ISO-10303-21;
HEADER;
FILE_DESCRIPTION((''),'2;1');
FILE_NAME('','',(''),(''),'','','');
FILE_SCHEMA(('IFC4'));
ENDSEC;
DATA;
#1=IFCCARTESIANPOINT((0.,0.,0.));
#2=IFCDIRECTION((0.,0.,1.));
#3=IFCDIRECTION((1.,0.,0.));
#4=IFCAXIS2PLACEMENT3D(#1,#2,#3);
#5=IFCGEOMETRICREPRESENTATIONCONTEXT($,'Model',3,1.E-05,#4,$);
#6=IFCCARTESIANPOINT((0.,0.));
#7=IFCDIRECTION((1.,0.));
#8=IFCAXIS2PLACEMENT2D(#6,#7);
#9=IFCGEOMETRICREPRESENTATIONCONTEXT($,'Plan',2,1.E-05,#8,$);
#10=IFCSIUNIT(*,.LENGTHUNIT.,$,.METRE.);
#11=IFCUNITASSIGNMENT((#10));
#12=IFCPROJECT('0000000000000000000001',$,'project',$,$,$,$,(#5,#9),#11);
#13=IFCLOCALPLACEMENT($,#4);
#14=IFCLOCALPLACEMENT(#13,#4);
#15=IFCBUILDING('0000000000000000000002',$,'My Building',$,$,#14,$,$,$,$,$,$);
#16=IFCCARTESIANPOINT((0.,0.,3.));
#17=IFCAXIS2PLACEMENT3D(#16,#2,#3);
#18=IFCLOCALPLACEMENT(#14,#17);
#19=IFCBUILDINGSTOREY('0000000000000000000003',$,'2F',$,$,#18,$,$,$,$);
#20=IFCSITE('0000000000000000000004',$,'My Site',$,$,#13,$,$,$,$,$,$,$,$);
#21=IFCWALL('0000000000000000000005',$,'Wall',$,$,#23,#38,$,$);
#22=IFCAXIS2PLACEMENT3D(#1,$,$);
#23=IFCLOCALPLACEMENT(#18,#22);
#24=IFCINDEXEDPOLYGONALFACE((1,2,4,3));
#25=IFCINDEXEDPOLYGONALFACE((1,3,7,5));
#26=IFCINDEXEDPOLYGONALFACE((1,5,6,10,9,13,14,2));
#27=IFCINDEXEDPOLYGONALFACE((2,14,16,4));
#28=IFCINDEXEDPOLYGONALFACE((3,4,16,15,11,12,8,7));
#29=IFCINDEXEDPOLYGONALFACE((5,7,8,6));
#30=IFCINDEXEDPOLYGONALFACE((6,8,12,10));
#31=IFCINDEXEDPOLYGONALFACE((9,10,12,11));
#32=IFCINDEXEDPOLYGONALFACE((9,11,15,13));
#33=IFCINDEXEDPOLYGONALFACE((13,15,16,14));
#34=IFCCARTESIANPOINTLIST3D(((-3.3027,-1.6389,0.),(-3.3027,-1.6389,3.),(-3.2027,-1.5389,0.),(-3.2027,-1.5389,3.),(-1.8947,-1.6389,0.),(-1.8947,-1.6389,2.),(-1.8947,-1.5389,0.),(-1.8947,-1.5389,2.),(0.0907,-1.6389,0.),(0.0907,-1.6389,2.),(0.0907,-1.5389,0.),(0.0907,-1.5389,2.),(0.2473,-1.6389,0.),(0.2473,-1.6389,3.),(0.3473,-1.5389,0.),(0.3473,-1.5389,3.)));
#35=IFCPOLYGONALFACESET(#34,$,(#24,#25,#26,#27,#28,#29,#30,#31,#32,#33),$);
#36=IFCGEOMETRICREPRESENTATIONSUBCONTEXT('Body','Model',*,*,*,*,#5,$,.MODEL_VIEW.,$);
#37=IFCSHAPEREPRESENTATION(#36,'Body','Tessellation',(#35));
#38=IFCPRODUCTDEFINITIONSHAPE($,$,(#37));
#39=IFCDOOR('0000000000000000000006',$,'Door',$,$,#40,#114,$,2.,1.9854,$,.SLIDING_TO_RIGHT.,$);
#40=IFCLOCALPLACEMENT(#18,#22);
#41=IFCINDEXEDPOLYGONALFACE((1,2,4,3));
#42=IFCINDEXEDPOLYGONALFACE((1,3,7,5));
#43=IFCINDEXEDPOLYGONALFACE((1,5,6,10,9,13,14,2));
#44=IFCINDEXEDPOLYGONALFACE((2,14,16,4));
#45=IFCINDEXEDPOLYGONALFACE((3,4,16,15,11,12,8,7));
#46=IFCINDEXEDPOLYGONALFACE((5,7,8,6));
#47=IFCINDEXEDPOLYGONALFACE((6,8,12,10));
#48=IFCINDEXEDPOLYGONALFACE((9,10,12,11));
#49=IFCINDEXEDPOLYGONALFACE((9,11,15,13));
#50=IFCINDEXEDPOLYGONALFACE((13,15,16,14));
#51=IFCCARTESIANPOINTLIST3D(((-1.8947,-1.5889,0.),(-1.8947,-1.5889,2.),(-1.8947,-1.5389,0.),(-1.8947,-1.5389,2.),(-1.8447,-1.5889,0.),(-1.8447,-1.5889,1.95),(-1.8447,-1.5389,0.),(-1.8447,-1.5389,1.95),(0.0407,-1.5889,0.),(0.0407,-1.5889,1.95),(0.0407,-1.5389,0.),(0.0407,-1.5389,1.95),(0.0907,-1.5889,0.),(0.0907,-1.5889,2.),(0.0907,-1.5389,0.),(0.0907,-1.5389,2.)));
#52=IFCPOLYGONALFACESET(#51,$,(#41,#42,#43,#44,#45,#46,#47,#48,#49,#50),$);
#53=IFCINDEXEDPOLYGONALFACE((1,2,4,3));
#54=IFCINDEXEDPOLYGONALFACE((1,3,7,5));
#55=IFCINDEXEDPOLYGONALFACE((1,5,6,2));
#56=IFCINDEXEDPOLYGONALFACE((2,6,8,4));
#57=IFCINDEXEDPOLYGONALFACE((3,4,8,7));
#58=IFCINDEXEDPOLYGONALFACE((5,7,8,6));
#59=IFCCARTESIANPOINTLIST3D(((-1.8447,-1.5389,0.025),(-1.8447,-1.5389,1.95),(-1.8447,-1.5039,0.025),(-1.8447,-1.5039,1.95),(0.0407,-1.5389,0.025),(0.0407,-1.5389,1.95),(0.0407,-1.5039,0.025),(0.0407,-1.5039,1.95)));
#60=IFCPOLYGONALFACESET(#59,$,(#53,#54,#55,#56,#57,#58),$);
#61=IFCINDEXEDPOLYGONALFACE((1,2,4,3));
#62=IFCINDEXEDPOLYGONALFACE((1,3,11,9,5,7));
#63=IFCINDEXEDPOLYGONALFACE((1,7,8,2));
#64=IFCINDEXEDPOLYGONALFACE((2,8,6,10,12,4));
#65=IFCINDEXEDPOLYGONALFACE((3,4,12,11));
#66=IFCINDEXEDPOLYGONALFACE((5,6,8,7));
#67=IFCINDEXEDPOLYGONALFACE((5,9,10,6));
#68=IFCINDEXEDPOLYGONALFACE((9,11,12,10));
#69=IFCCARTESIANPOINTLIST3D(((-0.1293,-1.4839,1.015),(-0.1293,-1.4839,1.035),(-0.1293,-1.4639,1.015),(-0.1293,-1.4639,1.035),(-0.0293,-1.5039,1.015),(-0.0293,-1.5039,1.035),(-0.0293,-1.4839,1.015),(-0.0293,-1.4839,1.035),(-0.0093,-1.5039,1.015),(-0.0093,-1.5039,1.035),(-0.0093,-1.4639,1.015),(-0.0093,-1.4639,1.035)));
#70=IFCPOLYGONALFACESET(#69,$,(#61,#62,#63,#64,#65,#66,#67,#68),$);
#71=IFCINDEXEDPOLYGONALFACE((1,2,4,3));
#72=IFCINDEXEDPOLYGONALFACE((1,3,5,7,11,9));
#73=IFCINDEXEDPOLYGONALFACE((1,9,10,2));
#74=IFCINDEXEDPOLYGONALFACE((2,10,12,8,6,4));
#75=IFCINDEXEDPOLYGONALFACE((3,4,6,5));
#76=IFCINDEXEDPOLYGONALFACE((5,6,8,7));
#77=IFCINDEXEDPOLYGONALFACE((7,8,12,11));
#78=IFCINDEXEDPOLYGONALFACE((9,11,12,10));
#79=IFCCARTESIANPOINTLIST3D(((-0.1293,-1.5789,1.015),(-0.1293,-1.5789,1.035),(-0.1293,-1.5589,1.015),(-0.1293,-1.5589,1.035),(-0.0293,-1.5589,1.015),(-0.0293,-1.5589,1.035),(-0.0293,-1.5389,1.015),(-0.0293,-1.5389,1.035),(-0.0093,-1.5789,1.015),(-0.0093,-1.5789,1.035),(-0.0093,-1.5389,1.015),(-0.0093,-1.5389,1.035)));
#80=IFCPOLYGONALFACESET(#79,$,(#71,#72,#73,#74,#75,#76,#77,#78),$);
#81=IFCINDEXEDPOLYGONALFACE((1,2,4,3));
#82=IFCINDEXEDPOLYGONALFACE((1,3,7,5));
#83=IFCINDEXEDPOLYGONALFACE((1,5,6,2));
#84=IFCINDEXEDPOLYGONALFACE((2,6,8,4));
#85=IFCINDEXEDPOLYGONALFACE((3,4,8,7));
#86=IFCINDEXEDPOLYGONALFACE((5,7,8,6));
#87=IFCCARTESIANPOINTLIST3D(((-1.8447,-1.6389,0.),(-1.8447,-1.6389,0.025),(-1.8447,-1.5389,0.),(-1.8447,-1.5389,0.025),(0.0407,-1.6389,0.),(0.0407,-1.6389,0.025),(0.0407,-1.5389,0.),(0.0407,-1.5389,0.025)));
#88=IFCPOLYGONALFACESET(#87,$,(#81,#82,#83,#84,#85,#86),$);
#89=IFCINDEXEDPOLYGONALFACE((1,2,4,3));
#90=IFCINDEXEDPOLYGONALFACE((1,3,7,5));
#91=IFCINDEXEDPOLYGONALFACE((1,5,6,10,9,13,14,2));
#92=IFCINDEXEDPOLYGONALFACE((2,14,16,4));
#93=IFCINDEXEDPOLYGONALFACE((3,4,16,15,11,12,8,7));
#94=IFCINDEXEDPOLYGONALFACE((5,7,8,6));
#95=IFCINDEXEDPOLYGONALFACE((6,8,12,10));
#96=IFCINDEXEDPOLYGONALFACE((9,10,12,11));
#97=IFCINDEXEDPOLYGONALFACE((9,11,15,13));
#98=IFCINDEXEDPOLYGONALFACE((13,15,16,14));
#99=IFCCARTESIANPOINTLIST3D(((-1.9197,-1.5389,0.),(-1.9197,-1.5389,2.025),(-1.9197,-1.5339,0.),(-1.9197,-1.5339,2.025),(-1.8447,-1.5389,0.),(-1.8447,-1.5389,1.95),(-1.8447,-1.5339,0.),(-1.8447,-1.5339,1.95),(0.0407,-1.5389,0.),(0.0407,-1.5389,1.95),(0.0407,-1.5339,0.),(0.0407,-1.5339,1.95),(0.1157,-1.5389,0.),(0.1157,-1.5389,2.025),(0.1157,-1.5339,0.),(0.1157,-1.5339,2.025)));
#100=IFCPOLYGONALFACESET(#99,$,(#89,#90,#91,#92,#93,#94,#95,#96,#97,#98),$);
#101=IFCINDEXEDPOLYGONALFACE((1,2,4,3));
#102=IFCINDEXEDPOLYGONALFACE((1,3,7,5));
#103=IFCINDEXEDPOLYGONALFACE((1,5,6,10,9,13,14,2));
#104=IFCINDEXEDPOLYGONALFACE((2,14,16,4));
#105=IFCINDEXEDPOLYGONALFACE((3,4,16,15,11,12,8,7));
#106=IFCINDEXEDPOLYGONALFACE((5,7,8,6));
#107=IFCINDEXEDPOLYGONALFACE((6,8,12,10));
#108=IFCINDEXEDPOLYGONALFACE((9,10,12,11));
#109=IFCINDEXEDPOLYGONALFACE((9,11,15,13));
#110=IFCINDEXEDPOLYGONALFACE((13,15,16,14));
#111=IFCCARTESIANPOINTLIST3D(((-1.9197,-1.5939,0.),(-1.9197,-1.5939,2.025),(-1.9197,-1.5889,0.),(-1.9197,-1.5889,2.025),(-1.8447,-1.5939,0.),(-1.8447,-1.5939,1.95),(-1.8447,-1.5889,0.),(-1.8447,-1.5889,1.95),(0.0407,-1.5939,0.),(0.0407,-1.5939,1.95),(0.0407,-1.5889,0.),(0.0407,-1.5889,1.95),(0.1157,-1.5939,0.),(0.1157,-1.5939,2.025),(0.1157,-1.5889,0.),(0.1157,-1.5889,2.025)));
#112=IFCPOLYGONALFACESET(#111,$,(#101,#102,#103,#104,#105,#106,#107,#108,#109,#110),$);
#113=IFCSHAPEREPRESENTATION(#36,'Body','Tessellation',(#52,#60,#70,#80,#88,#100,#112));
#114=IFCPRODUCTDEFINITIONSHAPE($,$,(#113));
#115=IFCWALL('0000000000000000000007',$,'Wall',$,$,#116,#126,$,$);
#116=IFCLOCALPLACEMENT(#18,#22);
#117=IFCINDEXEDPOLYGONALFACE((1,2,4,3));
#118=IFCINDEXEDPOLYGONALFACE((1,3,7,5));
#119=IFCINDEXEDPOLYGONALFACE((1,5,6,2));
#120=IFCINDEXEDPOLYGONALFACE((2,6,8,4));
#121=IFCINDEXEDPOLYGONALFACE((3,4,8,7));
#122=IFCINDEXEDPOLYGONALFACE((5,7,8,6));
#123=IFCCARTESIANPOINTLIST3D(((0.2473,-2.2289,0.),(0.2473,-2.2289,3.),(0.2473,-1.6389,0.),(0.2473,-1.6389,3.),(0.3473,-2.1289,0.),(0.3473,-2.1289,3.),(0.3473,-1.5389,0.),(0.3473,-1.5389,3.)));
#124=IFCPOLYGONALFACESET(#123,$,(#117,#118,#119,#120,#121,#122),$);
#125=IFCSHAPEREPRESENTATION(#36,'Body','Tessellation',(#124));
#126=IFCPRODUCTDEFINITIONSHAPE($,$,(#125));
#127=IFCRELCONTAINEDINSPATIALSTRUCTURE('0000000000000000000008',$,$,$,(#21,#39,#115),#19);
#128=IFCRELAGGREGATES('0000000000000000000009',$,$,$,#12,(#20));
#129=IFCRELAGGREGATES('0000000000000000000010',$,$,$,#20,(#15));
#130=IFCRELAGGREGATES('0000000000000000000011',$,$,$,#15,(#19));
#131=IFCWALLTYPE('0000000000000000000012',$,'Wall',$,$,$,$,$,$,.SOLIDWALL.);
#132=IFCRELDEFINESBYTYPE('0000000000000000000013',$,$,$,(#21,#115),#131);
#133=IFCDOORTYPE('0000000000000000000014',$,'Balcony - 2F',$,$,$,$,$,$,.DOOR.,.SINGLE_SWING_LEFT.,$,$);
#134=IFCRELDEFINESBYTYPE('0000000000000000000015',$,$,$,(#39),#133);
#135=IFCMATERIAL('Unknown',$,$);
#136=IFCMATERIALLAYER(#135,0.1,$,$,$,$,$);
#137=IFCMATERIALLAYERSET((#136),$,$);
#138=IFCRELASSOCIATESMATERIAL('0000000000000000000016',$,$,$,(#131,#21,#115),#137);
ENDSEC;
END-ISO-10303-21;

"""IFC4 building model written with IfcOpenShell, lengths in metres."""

from ifc_helpers import new_model, entity, si_unit, frame, origin_with_axes, origin_2d_with_axis, place, context, subcontext, project, spatial, line, indexed_curve, outline, extrude, shape, source, transform, mapped, material, layer, layer_set, layer_usage, type_object, type_shapes, element, fill, save


model = new_model("IFC4")

# Units and contexts
model_context = context("Model", 3, precision=1e-05, world=origin_with_axes())
plan_context = context("Plan", 2, precision=1e-05, world=origin_2d_with_axis())
body_context_1 = subcontext(model_context, "Body", "Model", "MODEL_VIEW")
body_context_2 = subcontext(plan_context, "Body", "Plan", "PLAN_VIEW")
ifc_project = project(units=[si_unit("LENGTHUNIT", "METRE")], contexts=[model_context, plan_context])

# Site, building, storey
site_placement = place(None, origin_with_axes())
site = spatial("IfcSite", under=ifc_project, at=site_placement, Name="My Site")
building_placement = place(site_placement, origin_with_axes())
building = spatial("IfcBuilding", under=site, at=building_placement, Name="My Building")
storey_placement = place(building_placement, frame((0.0, 0.0, 3.0), z_axis=(0.0, 0.0, 1.0), x_axis=(1.0, 0.0, 0.0)))
storey = spatial("IfcBuildingStorey", under=building, at=storey_placement, Name="2F")

# Shared definitions
ifc_material_1 = material(Name="Unknown")
ifc_layer_1 = layer(ifc_material_1, 0.1)
ifc_layer_set_1 = layer_set([ifc_layer_1])
wall_type_1 = type_object("IfcWallType", Name="Wall", PredefinedType="SOLIDWALL", material=ifc_layer_set_1)

# Wall, opening, door
ifc_layer_usage_1 = layer_usage(ifc_layer_set_1, "AXIS2", "POSITIVE", 0.0)
wall_1_placement = place(storey_placement, frame((-3.3027, -1.6389, 0.0), z_axis=(0.0, 0.0, 1.0), x_axis=(1.0, 0.0, 0.0)))
wall_1 = element("IfcWall", 1, at=wall_1_placement, inside=storey, type_object=wall_type_1, material=ifc_layer_usage_1, Name="Wall", context=body_context_1, shape_type="SweptSolid", body=[
    extrude(outline(indexed_curve([(0.0, 0.0), (0.1, 0.1), (3.65, 0.1), (3.55, 0.0)], segments=[line(1, 2, 3, 4, 1)])), origin_with_axes(), (0.0, 0.0, 1.0), 3.0),
])
shared_shape_1 = source(origin_with_axes(), body_context_1, "Body", "SweptSolid", [
    extrude(outline(indexed_curve([(0.0, 0.0), (1.9854, 0.0), (1.9854, 2.0), (0.0, 2.0)], segments=[line(1, 2, 3, 4, 1)])), frame((0.0, -0.6, 0.0), z_axis=(0.0, -1.0, 0.0), x_axis=(1.0, 0.0, 0.0)), (0.0, 0.0, -1.0), 1.2),
])
opening_1_placement = place(wall_1_placement, frame((3.3934, 0.1, 0.0), z_axis=(0.0, 0.0, 1.0), x_axis=(-1.0, 0.0, 0.0)))
opening_1 = element("IfcOpeningElement", 2, at=opening_1_placement, cuts=wall_1, PredefinedType="OPENING", context=body_context_1, shape_type="MappedRepresentation", body=[
    mapped(shared_shape_1, transform((0.0, 0.0, 0.0), x_axis=(1.0, 0.0, 0.0), y_axis=(0.0, 1.0, 0.0), z_axis=(0.0, 0.0, 1.0), scale=1.0)),
])
door_type_1 = type_object("IfcDoorType", Name="Balcony - 2F", OperationType="SINGLE_SWING_LEFT", PredefinedType="DOOR")
shared_shape_2 = source(origin_with_axes(), body_context_1, "Body", "SweptSolid", [
    extrude(outline(indexed_curve([(0.0, 0.0), (0.0, 2.0), (1.9854, 2.0), (1.9854, 0.0), (1.9354, 0.0), (1.9354, 1.95), (0.05, 1.95), (0.05, 0.0)], segments=[line(1, 2, 3, 4, 5, 6, 7, 8, 1)])), frame((0.0, 0.0, 0.0), z_axis=(0.0, -1.0, 0.0), x_axis=(1.0, 0.0, 0.0)), (0.0, 0.0, -1.0), 0.05),
    extrude(outline(indexed_curve([(0.0, 0.0), (1.8854, 0.0), (1.8854, 0.035), (0.0, 0.035)], segments=[line(1, 2, 3, 4, 1)])), frame((0.05, -0.035, 0.025), z_axis=(0.0, 0.0, 1.0), x_axis=(1.0, 0.0, 0.0)), (0.0, 0.0, 1.0), 1.925),
    extrude(outline(indexed_curve([(0.0, 0.0), (0.0, -0.04), (0.12, -0.04), (0.12, -0.02), (0.02, -0.02), (0.02, 0.0)], segments=[line(1, 2, 3, 4, 5, 6, 1)])), frame((0.1, -0.035, 1.015), z_axis=(0.0, 0.0, 1.0), x_axis=(1.0, 0.0, 0.0)), (0.0, 0.0, 1.0), 0.02),
    extrude(outline(indexed_curve([(0.0, 0.0), (0.0, 0.04), (0.12, 0.04), (0.12, 0.02), (0.02, 0.02), (0.02, 0.0)], segments=[line(1, 2, 3, 4, 5, 6, 1)])), frame((0.1, 0.0, 1.015), z_axis=(0.0, 0.0, 1.0), x_axis=(1.0, 0.0, 0.0)), (0.0, 0.0, 1.0), 0.02),
    extrude(outline(indexed_curve([(0.0, 0.0), (1.8854, 0.0), (1.8854, 0.1), (0.0, 0.1)], segments=[line(1, 2, 3, 4, 1)])), frame((0.05, 0.0, 0.0), z_axis=(0.0, 0.0, 1.0), x_axis=(1.0, 0.0, 0.0)), (0.0, 0.0, 1.0), 0.025),
    extrude(outline(indexed_curve([(0.0, 0.0), (0.0, 2.025), (2.0354, 2.025), (2.0354, 0.0), (1.9604, 0.0), (1.9604, 1.95), (0.075, 1.95), (0.075, 0.0)], segments=[line(1, 2, 3, 4, 5, 6, 7, 8, 1)])), frame((-0.025, -0.005, 0.0), z_axis=(0.0, -1.0, 0.0), x_axis=(1.0, 0.0, 0.0)), (0.0, 0.0, -1.0), 0.005),
    extrude(outline(indexed_curve([(0.0, 0.0), (0.0, 2.025), (2.0354, 2.025), (2.0354, 0.0), (1.9604, 0.0), (1.9604, 1.95), (0.075, 1.95), (0.075, 0.0)], segments=[line(1, 2, 3, 4, 5, 6, 7, 8, 1)])), frame((-0.025, 0.05, 0.0), z_axis=(0.0, -1.0, 0.0), x_axis=(1.0, 0.0, 0.0)), (0.0, 0.0, -1.0), 0.005),
])
shared_shape_3 = source(origin_with_axes(), body_context_2, "Body", "Curve2D", [
    entity("IfcIndexedPolyCurve", entity("IfcCartesianPointList2D", [[0.0, 0.0], [0.05, 0.0], [0.05, 0.05], [0.0, 0.05]]), [entity("IfcLineIndex", [1, 2, 3, 4, 1])]),
    entity("IfcIndexedPolyCurve", entity("IfcCartesianPointList2D", [[1.9854, 0.0], [1.9354, 0.0], [1.9354, 0.05], [1.9854, 0.05]]), [entity("IfcLineIndex", [1, 2, 3, 4, 1])]),
    entity("IfcIndexedPolyCurve", entity("IfcCartesianPointList2D", [[2.8782, -0.035], [0.9927, -0.035], [0.9927, 0.0], [2.8782, 0.0]]), [entity("IfcLineIndex", [1, 2, 3, 4, 1])]),
])
type_shapes(door_type_1, [shared_shape_2, shared_shape_3])
door_1_placement = place(opening_1_placement, frame((0.0, 0.0, 0.0), z_axis=(0.0, 0.0, 1.0), x_axis=(1.0, 0.0, 0.0)))
door_1 = element("IfcDoor", 3, at=door_1_placement, inside=storey, type_object=door_type_1, Name="Door", OperationType="SLIDING_TO_RIGHT", OverallHeight=2.0, OverallWidth=1.9854, shapes=[
    shape(body_context_1, "Body", "MappedRepresentation", [mapped(shared_shape_2, transform((0.0, 0.0, 0.0), x_axis=(1.0, 0.0, 0.0), y_axis=(0.0, 1.0, 0.0), z_axis=(0.0, 0.0, 1.0), scale=1.0))]),
    shape(body_context_2, "Body", "MappedRepresentation", [mapped(shared_shape_3, transform((0.0, 0.0, 0.0), x_axis=(1.0, 0.0, 0.0), y_axis=(0.0, 1.0, 0.0), z_axis=(0.0, 0.0, 1.0), scale=1.0))]),
])
fill(opening_1, door_1)

# Wall
ifc_layer_usage_2 = layer_usage(ifc_layer_set_1, "AXIS2", "POSITIVE", 0.0)
wall_2_placement = place(storey_placement, frame((0.2473, -1.6389, 0.0), z_axis=(0.0, 0.0, 1.0), x_axis=(0.0, -1.0, 0.0)))
element("IfcWall", 4, at=wall_2_placement, inside=storey, type_object=wall_type_1, material=ifc_layer_usage_2, Name="Wall", context=body_context_1, shape_type="SweptSolid", body=[
    extrude(outline(indexed_curve([(0.0, 0.0), (-0.1, 0.1), (0.49, 0.1), (0.59, 0.0)], segments=[line(1, 2, 3, 4, 1)])), origin_with_axes(), (0.0, 0.0, 1.0), 3.0),
])

save(model, "model.ifc")
